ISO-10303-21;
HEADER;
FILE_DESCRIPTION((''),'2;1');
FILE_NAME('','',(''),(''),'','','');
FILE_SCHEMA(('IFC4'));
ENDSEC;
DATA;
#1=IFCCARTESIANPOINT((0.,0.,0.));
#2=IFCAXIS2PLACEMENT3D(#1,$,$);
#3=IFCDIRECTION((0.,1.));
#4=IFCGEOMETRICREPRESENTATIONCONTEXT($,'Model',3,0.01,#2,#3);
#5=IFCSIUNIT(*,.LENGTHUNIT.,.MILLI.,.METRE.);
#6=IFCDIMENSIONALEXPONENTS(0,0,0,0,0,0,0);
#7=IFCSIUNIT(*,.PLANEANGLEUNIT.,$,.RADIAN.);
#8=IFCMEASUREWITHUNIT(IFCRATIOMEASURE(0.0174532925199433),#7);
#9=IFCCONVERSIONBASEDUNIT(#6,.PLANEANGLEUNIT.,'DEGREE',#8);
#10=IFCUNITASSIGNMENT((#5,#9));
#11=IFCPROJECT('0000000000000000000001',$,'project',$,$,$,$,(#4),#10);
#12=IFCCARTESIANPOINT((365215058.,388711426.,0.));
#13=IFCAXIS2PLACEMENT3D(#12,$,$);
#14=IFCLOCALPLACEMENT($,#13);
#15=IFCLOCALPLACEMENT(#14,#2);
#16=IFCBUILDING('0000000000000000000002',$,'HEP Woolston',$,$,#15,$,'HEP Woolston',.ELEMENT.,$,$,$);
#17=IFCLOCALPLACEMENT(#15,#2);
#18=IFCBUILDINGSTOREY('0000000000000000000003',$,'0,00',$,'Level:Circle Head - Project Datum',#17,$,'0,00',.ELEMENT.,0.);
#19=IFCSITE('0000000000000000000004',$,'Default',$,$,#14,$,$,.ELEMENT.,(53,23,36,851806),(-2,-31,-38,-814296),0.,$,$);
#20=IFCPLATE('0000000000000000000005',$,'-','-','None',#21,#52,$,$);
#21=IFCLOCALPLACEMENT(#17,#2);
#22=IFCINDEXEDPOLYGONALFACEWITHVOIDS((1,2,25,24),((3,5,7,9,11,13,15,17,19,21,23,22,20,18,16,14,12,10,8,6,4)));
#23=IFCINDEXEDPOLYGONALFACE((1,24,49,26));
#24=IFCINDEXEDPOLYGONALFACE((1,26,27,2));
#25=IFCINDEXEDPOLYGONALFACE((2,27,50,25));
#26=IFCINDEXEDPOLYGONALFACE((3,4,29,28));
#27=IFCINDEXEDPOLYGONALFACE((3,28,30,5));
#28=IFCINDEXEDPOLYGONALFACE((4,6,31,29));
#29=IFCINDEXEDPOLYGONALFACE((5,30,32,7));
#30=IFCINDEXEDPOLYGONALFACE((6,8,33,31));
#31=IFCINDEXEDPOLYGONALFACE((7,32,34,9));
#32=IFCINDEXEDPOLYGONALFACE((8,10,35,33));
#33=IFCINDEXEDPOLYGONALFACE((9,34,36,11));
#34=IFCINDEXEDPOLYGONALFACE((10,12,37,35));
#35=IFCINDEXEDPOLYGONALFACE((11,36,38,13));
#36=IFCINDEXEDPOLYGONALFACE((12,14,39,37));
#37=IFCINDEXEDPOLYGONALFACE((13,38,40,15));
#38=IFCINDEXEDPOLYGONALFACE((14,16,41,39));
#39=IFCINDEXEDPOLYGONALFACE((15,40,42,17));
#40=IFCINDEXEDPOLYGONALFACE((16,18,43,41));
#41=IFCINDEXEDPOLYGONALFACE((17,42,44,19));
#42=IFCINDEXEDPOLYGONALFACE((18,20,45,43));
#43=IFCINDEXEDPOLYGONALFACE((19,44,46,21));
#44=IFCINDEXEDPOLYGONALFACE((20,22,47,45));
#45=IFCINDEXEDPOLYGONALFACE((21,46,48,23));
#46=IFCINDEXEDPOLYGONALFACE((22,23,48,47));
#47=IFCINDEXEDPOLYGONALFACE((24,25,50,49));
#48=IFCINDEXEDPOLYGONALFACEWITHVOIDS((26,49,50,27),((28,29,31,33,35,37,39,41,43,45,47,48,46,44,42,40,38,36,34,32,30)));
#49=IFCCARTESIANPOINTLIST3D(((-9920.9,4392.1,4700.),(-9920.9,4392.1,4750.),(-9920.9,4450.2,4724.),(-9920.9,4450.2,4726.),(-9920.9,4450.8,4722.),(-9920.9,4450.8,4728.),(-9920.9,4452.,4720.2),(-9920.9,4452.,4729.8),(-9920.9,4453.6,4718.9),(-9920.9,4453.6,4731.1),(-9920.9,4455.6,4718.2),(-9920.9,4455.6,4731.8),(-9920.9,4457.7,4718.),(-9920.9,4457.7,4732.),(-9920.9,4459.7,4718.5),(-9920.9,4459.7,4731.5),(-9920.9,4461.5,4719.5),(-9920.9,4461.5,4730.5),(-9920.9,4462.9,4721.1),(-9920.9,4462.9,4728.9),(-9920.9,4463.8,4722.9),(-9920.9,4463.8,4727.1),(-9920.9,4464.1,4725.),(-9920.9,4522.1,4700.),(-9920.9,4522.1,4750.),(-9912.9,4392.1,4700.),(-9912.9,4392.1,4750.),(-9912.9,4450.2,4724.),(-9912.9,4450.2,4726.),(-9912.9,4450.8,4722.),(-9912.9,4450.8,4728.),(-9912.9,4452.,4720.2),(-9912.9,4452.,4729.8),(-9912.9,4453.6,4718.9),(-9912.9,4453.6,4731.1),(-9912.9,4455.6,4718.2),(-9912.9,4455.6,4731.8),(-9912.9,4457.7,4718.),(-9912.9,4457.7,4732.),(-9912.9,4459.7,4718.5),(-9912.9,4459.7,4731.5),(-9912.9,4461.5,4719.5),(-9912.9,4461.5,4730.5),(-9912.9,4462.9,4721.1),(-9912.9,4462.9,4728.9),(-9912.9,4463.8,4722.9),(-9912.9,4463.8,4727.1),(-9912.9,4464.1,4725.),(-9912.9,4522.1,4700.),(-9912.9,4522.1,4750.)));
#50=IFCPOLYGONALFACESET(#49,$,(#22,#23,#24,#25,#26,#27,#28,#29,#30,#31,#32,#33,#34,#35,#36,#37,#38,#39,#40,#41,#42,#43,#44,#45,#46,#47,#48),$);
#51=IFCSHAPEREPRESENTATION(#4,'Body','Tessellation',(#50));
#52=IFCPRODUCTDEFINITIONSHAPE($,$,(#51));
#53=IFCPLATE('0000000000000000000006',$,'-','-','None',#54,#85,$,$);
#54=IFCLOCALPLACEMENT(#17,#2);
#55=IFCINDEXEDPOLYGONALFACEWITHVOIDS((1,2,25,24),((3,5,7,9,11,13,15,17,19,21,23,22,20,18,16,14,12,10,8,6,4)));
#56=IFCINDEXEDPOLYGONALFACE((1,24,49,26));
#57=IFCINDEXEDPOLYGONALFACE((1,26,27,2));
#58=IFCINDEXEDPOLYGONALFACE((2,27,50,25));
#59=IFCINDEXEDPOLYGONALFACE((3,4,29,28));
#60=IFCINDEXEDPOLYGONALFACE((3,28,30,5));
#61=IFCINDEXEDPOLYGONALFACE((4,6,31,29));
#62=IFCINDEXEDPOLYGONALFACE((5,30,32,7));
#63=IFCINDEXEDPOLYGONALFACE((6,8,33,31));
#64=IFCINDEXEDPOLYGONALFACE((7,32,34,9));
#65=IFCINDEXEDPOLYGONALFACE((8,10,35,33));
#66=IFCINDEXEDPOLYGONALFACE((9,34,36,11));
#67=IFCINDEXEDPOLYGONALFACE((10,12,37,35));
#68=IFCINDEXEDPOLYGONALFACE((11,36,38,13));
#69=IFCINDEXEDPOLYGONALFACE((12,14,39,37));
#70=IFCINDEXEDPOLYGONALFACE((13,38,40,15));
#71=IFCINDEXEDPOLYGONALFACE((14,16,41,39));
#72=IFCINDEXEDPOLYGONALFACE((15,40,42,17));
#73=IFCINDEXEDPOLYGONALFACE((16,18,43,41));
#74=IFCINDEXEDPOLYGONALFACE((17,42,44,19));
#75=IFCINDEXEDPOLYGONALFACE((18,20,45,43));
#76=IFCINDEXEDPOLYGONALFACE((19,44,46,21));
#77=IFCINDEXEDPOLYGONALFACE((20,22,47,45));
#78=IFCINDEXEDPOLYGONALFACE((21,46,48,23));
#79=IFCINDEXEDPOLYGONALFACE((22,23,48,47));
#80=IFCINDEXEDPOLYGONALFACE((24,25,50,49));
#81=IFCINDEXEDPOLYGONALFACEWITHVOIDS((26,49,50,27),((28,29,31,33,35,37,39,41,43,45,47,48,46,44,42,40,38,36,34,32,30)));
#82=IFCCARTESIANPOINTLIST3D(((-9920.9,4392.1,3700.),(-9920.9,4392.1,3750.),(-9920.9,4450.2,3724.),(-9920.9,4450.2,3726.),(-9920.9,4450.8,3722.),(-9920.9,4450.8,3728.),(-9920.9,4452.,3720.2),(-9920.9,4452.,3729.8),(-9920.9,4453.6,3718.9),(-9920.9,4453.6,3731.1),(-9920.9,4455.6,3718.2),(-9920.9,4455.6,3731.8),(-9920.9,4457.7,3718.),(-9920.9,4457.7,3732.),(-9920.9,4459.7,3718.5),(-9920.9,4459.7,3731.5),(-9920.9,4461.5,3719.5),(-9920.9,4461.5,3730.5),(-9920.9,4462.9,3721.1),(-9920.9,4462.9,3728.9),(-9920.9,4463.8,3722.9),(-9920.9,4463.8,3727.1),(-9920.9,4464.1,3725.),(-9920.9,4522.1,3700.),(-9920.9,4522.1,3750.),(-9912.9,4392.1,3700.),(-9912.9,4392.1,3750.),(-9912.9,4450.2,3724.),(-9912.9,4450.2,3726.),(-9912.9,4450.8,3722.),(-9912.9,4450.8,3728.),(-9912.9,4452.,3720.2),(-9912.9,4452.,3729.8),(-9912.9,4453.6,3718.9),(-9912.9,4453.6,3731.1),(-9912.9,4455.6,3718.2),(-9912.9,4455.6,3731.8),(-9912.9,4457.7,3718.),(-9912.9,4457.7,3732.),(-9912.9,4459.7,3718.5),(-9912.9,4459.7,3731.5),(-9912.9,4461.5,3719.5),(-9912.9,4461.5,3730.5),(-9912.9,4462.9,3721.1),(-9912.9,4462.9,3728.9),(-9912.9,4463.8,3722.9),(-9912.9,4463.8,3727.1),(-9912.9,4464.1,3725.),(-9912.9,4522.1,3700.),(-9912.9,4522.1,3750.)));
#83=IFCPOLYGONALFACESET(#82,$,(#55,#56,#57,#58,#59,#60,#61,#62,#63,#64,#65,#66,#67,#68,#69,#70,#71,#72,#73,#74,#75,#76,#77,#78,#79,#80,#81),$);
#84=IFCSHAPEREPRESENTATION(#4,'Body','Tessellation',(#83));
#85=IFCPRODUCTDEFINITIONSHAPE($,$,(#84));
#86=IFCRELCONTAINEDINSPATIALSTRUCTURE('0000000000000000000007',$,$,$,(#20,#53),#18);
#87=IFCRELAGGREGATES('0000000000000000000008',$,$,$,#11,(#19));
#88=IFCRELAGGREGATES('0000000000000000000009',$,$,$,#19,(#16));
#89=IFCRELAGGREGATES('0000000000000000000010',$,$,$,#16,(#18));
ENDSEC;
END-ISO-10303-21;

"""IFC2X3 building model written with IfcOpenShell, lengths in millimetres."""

from ifc_helpers import new_model, entity, si_unit, converted_unit, direction, frame, origin, origin_with_axes, origin_2d_with_axis, place, context, project, spatial, polyline, circle, outline, extrude, element, save


model = new_model("IFC2X3")

# Units and contexts
model_context = context("Model", 3, precision=0.01, world=origin(), true_north=direction((0.0, 1.0)))
ifc_project = project(units=[si_unit("LENGTHUNIT", "METRE", prefix="MILLI"), converted_unit("PLANEANGLEUNIT", "DEGREE", entity("IfcRatioMeasure", 0.0174532925199433), si_unit("PLANEANGLEUNIT", "RADIAN"), dimensions=[0, 0, 0, 0, 0, 0, 0])], contexts=[model_context])

# Site, building, storey
site_placement = place(None, frame((365215058.0, 388711426.0, 0.0)))
site = spatial("IfcSite", under=ifc_project, at=site_placement, Name="Default", CompositionType="ELEMENT", RefLatitude=(53, 23, 36, 851806), RefLongitude=(-2, -31, -38, -814296), RefElevation=0.0)
building_placement = place(site_placement, origin())
building = spatial("IfcBuilding", under=site, at=building_placement, Name="HEP Woolston", LongName="HEP Woolston", CompositionType="ELEMENT")
storey_placement = place(building_placement, origin())
storey = spatial("IfcBuildingStorey", under=building, at=storey_placement, Name="0,00", ObjectType="Level:Circle Head - Project Datum", LongName="0,00", CompositionType="ELEMENT", Elevation=0.0)

# Plates, openings
plate_1_placement = place(storey_placement, frame((-9920.9, 4392.1, 4750.0), z_axis=(1.0, 0.0, 0.0), x_axis=(0.0, 1.0, 0.0)))
plate_1 = element("IfcPlate", 1, at=plate_1_placement, inside=storey, Name="-", Description="-", ObjectType="None", context=model_context, shape_type="SweptSolid", body=[
    extrude(outline(polyline([(0.0, -50.0), (130.0, -50.0), (130.0, 0.0), (0.0, 0.0), (0.0, -50.0)])), origin_with_axes(), (0.0, 0.0, 1.0), 8.0),
])
opening_1_placement = place(plate_1_placement, frame((65.0, -25.0, 8.5), z_axis=(0.0, 0.0, -1.0), x_axis=(1.0, 0.0, 0.0)))
element("IfcOpeningElement", 2, at=opening_1_placement, cuts=plate_1, ObjectType="Opening", context=model_context, shape_type="SweptSolid", body=[
    extrude(circle(Radius=7.0, at=origin_2d_with_axis()), origin(), (0.0, 0.0, 1.0), 9.0),
])
plate_2_placement = place(storey_placement, frame((-9920.9, 4392.1, 3750.0), z_axis=(1.0, 0.0, 0.0), x_axis=(0.0, 1.0, 0.0)))
plate_2 = element("IfcPlate", 3, at=plate_2_placement, inside=storey, Name="-", Description="-", ObjectType="None", context=model_context, shape_type="SweptSolid", body=[
    extrude(outline(polyline([(0.0, -50.0), (130.0, -50.0), (130.0, 0.0), (0.0, 0.0), (0.0, -50.0)])), origin_with_axes(), (0.0, 0.0, 1.0), 8.0),
])
opening_2_placement = place(plate_2_placement, frame((65.0, -25.0, 8.5), z_axis=(0.0, 0.0, -1.0), x_axis=(1.0, 0.0, 0.0)))
element("IfcOpeningElement", 4, at=opening_2_placement, cuts=plate_2, ObjectType="Opening", context=model_context, shape_type="SweptSolid", body=[
    extrude(circle(Radius=7.0, at=origin_2d_with_axis()), origin(), (0.0, 0.0, 1.0), 9.0),
])

save(model, "model.ifc")
